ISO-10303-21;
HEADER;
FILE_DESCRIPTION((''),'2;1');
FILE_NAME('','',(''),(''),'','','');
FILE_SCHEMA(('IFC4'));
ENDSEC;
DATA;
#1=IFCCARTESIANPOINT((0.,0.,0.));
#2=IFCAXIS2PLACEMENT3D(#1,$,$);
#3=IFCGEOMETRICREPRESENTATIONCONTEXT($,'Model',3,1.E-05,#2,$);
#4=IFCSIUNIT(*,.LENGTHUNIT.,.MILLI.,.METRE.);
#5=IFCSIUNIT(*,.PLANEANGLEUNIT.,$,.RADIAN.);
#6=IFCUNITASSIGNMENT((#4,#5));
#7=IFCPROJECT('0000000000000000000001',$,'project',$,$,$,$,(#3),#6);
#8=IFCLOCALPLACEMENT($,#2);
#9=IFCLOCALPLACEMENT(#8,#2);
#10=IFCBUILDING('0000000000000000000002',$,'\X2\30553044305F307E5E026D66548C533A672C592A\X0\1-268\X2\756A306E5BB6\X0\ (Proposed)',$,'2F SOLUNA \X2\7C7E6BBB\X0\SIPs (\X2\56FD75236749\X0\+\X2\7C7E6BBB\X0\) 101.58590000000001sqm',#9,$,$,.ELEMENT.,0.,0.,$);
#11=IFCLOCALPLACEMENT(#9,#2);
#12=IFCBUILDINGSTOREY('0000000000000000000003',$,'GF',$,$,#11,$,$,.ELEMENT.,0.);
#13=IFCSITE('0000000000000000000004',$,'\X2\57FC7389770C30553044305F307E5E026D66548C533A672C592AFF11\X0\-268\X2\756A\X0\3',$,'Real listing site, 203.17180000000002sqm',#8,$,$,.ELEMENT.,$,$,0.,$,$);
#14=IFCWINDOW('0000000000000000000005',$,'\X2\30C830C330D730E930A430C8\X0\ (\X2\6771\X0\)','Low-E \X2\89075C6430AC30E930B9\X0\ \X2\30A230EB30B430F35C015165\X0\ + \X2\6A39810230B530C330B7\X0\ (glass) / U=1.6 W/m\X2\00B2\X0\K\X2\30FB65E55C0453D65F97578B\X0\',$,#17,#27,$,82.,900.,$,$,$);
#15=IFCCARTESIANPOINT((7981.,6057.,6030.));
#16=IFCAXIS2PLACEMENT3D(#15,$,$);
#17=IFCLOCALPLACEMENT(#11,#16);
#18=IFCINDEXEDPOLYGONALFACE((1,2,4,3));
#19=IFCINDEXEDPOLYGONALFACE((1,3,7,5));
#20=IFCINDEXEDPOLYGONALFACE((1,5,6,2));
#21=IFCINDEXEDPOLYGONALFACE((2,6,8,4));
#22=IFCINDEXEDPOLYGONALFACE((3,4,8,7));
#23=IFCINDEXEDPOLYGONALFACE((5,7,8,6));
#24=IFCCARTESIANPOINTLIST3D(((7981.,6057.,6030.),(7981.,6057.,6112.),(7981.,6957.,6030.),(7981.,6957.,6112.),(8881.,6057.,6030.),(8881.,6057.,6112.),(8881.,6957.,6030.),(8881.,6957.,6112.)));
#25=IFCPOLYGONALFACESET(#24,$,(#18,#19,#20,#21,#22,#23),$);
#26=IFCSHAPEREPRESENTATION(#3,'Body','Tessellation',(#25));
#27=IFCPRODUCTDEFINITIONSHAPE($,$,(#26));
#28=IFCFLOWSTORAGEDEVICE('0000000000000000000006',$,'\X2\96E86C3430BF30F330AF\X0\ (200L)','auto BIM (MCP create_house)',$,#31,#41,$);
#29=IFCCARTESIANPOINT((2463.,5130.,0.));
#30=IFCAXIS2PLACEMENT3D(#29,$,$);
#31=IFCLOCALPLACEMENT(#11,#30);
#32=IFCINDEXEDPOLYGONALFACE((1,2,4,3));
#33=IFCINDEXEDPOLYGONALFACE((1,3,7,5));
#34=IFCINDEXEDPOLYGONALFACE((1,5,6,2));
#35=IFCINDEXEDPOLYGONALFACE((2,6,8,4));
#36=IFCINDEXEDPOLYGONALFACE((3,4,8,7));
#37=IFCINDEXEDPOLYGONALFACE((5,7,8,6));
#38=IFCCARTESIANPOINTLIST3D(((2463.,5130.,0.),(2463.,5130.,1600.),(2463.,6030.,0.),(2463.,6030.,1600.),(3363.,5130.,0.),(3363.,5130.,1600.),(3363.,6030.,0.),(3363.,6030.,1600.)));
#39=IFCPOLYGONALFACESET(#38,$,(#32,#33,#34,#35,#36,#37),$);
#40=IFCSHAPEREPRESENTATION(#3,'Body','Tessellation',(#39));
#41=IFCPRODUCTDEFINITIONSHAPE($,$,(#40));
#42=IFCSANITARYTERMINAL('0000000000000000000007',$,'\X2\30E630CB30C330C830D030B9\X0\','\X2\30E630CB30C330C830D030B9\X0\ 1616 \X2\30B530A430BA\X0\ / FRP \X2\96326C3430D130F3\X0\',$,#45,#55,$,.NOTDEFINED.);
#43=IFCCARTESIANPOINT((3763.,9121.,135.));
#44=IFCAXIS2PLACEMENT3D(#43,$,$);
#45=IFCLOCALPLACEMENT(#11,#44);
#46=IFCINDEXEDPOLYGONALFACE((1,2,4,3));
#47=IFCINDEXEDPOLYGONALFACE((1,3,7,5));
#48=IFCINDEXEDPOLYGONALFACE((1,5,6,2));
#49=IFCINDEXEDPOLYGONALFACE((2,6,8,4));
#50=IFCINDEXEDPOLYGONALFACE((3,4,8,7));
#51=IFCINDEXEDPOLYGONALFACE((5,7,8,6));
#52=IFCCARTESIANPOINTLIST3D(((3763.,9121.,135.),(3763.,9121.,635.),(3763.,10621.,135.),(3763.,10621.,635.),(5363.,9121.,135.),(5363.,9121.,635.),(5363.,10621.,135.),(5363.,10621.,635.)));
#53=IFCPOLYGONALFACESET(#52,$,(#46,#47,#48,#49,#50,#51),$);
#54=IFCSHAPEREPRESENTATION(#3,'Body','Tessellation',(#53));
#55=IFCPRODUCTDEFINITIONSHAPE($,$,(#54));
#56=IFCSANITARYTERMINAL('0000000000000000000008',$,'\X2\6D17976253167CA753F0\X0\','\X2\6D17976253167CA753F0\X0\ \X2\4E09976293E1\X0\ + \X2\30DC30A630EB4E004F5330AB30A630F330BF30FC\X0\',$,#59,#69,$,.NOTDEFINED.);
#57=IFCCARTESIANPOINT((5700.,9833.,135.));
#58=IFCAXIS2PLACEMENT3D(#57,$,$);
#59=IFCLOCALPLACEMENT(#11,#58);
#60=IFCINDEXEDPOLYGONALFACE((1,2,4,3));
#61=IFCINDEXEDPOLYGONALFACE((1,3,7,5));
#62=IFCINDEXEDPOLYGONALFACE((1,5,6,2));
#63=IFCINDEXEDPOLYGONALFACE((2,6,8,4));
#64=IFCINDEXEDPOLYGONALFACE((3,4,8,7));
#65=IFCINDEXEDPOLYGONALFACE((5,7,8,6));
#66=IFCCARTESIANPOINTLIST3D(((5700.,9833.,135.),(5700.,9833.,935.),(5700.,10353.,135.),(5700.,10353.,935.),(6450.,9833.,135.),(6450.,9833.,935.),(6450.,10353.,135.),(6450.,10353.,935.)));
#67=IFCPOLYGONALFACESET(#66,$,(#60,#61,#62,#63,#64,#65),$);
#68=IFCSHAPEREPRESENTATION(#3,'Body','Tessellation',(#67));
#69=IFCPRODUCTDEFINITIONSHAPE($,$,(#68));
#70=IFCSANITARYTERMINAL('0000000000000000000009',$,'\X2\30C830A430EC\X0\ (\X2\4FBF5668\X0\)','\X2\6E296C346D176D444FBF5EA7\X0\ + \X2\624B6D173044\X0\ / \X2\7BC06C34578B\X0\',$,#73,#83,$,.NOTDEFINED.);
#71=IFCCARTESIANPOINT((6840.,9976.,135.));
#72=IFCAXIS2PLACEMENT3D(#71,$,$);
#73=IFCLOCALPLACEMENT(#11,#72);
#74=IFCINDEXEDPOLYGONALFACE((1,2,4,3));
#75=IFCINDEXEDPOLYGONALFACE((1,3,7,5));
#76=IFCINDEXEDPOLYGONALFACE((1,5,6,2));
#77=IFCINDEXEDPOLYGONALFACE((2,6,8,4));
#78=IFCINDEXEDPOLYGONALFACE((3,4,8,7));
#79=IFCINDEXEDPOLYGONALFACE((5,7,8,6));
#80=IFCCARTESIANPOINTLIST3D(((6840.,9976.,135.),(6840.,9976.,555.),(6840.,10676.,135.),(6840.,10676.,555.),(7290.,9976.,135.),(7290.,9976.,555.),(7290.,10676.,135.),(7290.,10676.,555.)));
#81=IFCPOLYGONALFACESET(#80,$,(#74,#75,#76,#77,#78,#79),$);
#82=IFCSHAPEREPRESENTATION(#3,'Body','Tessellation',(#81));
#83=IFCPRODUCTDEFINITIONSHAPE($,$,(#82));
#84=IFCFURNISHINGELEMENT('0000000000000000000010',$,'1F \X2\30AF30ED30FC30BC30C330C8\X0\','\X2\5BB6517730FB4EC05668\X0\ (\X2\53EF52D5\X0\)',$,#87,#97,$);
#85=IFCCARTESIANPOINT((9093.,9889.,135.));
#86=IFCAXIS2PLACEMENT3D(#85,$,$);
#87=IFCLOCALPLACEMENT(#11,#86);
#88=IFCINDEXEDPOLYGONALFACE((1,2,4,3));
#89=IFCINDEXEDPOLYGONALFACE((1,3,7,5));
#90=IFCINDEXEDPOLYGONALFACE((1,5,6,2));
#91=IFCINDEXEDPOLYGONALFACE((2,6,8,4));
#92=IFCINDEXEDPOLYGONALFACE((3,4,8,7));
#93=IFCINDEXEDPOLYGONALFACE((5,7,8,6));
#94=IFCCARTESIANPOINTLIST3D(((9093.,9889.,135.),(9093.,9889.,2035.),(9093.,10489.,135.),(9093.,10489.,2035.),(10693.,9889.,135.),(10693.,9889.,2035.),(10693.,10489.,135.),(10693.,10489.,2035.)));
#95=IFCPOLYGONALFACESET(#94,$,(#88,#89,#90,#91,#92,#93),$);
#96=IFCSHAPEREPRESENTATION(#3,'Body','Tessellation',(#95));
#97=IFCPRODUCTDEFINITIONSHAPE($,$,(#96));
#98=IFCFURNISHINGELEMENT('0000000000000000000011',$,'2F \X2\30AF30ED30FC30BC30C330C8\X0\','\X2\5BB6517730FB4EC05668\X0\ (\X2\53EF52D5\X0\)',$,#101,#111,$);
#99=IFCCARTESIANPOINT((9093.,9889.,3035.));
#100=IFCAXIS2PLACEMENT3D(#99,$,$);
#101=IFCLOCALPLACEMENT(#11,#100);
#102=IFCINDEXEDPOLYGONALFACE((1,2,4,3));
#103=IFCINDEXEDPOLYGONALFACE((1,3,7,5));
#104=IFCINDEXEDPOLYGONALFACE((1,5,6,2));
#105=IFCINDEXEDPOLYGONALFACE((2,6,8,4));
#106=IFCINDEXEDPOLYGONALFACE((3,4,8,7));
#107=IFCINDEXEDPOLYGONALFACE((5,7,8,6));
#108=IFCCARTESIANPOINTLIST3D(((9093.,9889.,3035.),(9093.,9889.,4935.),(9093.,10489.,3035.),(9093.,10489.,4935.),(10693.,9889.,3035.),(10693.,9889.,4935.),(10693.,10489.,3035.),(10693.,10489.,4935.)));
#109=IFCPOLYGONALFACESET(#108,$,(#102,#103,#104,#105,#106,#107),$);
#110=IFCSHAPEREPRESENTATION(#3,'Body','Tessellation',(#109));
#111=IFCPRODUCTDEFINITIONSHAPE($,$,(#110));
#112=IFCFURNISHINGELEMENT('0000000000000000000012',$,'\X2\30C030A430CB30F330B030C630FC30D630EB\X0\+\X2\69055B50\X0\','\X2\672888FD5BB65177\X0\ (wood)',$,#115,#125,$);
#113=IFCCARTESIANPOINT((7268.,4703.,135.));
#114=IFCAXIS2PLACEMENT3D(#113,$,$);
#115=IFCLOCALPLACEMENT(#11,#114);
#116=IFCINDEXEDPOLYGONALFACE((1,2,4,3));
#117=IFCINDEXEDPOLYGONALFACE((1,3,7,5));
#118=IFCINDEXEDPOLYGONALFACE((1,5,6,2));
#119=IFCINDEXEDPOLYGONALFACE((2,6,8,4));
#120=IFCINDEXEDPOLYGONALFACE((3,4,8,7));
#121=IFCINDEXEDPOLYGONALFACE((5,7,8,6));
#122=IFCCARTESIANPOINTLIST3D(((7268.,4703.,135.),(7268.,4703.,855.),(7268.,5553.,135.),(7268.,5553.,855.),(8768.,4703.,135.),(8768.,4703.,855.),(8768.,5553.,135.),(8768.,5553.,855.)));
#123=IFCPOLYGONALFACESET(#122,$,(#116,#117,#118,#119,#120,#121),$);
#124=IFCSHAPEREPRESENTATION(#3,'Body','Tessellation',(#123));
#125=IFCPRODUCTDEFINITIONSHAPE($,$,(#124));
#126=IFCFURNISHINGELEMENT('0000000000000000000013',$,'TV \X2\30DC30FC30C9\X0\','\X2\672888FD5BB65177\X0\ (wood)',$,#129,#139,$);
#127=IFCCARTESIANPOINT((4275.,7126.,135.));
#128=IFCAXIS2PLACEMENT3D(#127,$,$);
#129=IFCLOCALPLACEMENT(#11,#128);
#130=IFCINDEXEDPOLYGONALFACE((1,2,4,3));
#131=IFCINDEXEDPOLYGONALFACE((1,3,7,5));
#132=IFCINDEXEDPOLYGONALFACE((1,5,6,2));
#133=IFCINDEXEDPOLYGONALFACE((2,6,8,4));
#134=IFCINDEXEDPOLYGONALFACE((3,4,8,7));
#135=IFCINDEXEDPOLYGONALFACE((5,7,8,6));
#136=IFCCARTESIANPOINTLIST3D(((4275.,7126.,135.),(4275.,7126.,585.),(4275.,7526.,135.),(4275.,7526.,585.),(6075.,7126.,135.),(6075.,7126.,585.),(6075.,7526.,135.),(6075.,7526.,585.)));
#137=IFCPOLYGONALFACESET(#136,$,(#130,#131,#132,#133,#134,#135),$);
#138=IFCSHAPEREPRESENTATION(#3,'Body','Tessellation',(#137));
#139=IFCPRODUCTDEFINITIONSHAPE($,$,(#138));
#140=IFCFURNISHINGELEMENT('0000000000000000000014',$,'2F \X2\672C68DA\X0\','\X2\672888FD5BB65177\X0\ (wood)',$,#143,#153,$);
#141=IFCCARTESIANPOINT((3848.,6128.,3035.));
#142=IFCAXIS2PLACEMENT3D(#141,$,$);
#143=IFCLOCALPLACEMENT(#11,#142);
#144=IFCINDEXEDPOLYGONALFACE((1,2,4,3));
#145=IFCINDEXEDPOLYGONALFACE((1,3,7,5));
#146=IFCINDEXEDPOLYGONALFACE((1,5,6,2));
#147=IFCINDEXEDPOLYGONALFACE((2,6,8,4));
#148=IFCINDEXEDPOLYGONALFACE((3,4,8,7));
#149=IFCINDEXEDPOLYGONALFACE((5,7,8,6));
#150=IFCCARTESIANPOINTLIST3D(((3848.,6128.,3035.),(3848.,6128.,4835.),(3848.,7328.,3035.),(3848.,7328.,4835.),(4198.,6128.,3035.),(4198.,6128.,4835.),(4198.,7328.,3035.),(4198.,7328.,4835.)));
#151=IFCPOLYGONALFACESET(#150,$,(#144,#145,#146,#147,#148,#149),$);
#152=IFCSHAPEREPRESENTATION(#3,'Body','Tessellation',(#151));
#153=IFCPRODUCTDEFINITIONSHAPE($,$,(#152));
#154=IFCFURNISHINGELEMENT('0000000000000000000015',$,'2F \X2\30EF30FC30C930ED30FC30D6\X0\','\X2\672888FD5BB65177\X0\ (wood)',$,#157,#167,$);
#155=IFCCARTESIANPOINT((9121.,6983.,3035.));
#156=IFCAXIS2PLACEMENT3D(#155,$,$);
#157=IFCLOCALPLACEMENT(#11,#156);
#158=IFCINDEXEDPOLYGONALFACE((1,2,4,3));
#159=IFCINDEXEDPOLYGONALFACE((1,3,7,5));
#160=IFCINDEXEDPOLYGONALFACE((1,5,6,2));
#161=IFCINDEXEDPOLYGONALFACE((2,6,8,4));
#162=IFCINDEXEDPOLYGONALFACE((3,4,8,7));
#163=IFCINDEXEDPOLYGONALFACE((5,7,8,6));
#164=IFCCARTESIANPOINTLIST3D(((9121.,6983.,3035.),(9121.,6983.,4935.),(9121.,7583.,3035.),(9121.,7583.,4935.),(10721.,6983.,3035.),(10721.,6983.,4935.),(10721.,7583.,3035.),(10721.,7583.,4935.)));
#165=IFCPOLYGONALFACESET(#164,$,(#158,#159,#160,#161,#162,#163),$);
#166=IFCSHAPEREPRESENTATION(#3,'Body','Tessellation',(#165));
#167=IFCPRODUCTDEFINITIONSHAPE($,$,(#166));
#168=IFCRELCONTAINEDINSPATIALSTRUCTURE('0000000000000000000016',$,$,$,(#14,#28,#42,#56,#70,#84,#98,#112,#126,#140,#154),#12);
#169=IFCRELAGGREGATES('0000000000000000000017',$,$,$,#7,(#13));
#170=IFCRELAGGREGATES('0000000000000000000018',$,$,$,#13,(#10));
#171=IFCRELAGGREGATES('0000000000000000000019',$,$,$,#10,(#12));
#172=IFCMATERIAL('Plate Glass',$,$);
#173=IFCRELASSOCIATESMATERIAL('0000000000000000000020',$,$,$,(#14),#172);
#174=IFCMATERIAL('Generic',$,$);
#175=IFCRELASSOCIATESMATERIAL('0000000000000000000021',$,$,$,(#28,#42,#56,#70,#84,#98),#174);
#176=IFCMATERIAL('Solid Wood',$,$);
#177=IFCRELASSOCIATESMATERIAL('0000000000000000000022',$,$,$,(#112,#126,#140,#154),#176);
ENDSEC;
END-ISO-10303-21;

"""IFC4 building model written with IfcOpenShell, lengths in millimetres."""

from ifc_helpers import new_model, si_unit, frame, frame_2d, origin, place, context, project, spatial, rectangle, extrude, material, element, save


model = new_model("IFC4")

# Units and contexts
model_context = context("Model", 3, precision=1e-05, world=origin())
ifc_project = project(units=[si_unit("LENGTHUNIT", "METRE", prefix="MILLI"), si_unit("PLANEANGLEUNIT", "RADIAN")], contexts=[model_context])

# Site, building, storey
site_placement = place(None, origin())
site = spatial("IfcSite", under=ifc_project, at=site_placement, Name="埼玉県さいたま市浦和区本太１-268番3", ObjectType="Real listing site, 203.17180000000002sqm", CompositionType="ELEMENT", RefElevation=0.0)
building_placement = place(site_placement, origin())
building = spatial("IfcBuilding", under=site, at=building_placement, Name="さいたま市浦和区本太1-268番の家 (Proposed)", ObjectType="2F SOLUNA 籾殻SIPs (国産杉+籾殻) 101.58590000000001sqm", CompositionType="ELEMENT", ElevationOfRefHeight=0.0, ElevationOfTerrain=0.0)
storey_placement = place(building_placement, origin())
storey = spatial("IfcBuildingStorey", under=building, at=storey_placement, Name="GF", CompositionType="ELEMENT", Elevation=0.0)

# Shared definitions
ifc_material_1 = material(Name="Solid Wood")
ifc_material_2 = material(Name="Plate Glass")

# Window
window_1_placement = place(storey_placement, frame((7981.0, 6057.0, 6030.0)))
element("IfcWindow", 1, at=window_1_placement, inside=storey, material=ifc_material_2, Name="トップライト (東)", Description="Low-E 複層ガラス アルゴン封入 + 樹脂サッシ (glass) / U=1.6 W/m²K・日射取得型", OverallHeight=82.0, OverallWidth=900.0, context=model_context, shape_type="SweptSolid", body=[
    extrude(rectangle(XDim=900.0, YDim=900.0, at=frame_2d((450.0, 450.0))), frame((7981.0, 6057.0, 6030.0)), (0.0, 0.0, 1.0), 82.0),
])

# Flow storage device
ifc_material_3 = material(Name="Generic")
flow_storage_device_placement = place(storey_placement, frame((2463.0, 5130.0, 0.0)))
element("IfcFlowStorageDevice", 2, at=flow_storage_device_placement, inside=storey, material=ifc_material_3, Name="雨水タンク (200L)", Description="auto BIM (MCP create_house)", context=model_context, shape_type="SweptSolid", body=[
    extrude(rectangle(XDim=900.0, YDim=900.0, at=frame_2d((450.0, 450.0))), frame((2463.0, 5130.0, 0.0)), (0.0, 0.0, 1.0), 1600.0),
])

# Sanitary terminals
sanitary_terminal_1_placement = place(storey_placement, frame((3763.0, 9121.0, 135.0)))
element("IfcSanitaryTerminal", 3, at=sanitary_terminal_1_placement, inside=storey, material=ifc_material_3, Name="ユニットバス", Description="ユニットバス 1616 サイズ / FRP 防水パン", PredefinedType="NOTDEFINED", context=model_context, shape_type="SweptSolid", body=[
    extrude(rectangle(XDim=1600.0, YDim=1500.0, at=frame_2d((800.0, 750.0))), frame((3763.0, 9121.0, 135.0)), (0.0, 0.0, 1.0), 500.0),
])
sanitary_terminal_2_placement = place(storey_placement, frame((5700.0, 9833.0, 135.0)))
element("IfcSanitaryTerminal", 4, at=sanitary_terminal_2_placement, inside=storey, material=ifc_material_3, Name="洗面化粧台", Description="洗面化粧台 三面鏡 + ボウル一体カウンター", PredefinedType="NOTDEFINED", context=model_context, shape_type="SweptSolid", body=[
    extrude(rectangle(XDim=750.0, YDim=520.0, at=frame_2d((375.0, 260.0))), frame((5700.0, 9833.0, 135.0)), (0.0, 0.0, 1.0), 800.0),
])
sanitary_terminal_3_placement = place(storey_placement, frame((6840.0, 9976.0, 135.0)))
element("IfcSanitaryTerminal", 5, at=sanitary_terminal_3_placement, inside=storey, material=ifc_material_3, Name="トイレ (便器)", Description="温水洗浄便座 + 手洗い / 節水型", PredefinedType="NOTDEFINED", context=model_context, shape_type="SweptSolid", body=[
    extrude(rectangle(XDim=450.0, YDim=700.0, at=frame_2d((225.0, 350.0))), frame((6840.0, 9976.0, 135.0)), (0.0, 0.0, 1.0), 420.0),
])

# Furnishing elements
furnishing_1_placement = place(storey_placement, frame((9093.0, 9889.0, 135.0)))
element("IfcFurnishingElement", 6, at=furnishing_1_placement, inside=storey, material=ifc_material_3, Name="1F クローゼット", Description="家具・什器 (可動)", context=model_context, shape_type="SweptSolid", body=[
    extrude(rectangle(XDim=1600.0, YDim=600.0, at=frame_2d((800.0, 300.0))), frame((9093.0, 9889.0, 135.0)), (0.0, 0.0, 1.0), 1900.0),
])
furnishing_2_placement = place(storey_placement, frame((9093.0, 9889.0, 3035.0)))
element("IfcFurnishingElement", 7, at=furnishing_2_placement, inside=storey, material=ifc_material_3, Name="2F クローゼット", Description="家具・什器 (可動)", context=model_context, shape_type="SweptSolid", body=[
    extrude(rectangle(XDim=1600.0, YDim=600.0, at=frame_2d((800.0, 300.0))), frame((9093.0, 9889.0, 3035.0)), (0.0, 0.0, 1.0), 1900.0),
])
furnishing_3_placement = place(storey_placement, frame((7268.0, 4703.0, 135.0)))
element("IfcFurnishingElement", 8, at=furnishing_3_placement, inside=storey, material=ifc_material_1, Name="ダイニングテーブル+椅子", Description="木製家具 (wood)", context=model_context, shape_type="SweptSolid", body=[
    extrude(rectangle(XDim=1500.0, YDim=850.0, at=frame_2d((750.0, 425.0))), frame((7268.0, 4703.0, 135.0)), (0.0, 0.0, 1.0), 720.0),
])
furnishing_4_placement = place(storey_placement, frame((4275.0, 7126.0, 135.0)))
element("IfcFurnishingElement", 9, at=furnishing_4_placement, inside=storey, material=ifc_material_1, Name="TV ボード", Description="木製家具 (wood)", context=model_context, shape_type="SweptSolid", body=[
    extrude(rectangle(XDim=1800.0, YDim=400.0, at=frame_2d((900.0, 200.0))), frame((4275.0, 7126.0, 135.0)), (0.0, 0.0, 1.0), 450.0),
])
furnishing_5_placement = place(storey_placement, frame((3848.0, 6128.0, 3035.0)))
element("IfcFurnishingElement", 10, at=furnishing_5_placement, inside=storey, material=ifc_material_1, Name="2F 本棚", Description="木製家具 (wood)", context=model_context, shape_type="SweptSolid", body=[
    extrude(rectangle(XDim=350.0, YDim=1200.0, at=frame_2d((175.0, 600.0))), frame((3848.0, 6128.0, 3035.0)), (0.0, 0.0, 1.0), 1800.0),
])
furnishing_6_placement = place(storey_placement, frame((9121.0, 6983.0, 3035.0)))
element("IfcFurnishingElement", 11, at=furnishing_6_placement, inside=storey, material=ifc_material_1, Name="2F ワードローブ", Description="木製家具 (wood)", context=model_context, shape_type="SweptSolid", body=[
    extrude(rectangle(XDim=1600.0, YDim=600.0, at=frame_2d((800.0, 300.0))), frame((9121.0, 6983.0, 3035.0)), (0.0, 0.0, 1.0), 1900.0),
])

save(model, "model.ifc")
